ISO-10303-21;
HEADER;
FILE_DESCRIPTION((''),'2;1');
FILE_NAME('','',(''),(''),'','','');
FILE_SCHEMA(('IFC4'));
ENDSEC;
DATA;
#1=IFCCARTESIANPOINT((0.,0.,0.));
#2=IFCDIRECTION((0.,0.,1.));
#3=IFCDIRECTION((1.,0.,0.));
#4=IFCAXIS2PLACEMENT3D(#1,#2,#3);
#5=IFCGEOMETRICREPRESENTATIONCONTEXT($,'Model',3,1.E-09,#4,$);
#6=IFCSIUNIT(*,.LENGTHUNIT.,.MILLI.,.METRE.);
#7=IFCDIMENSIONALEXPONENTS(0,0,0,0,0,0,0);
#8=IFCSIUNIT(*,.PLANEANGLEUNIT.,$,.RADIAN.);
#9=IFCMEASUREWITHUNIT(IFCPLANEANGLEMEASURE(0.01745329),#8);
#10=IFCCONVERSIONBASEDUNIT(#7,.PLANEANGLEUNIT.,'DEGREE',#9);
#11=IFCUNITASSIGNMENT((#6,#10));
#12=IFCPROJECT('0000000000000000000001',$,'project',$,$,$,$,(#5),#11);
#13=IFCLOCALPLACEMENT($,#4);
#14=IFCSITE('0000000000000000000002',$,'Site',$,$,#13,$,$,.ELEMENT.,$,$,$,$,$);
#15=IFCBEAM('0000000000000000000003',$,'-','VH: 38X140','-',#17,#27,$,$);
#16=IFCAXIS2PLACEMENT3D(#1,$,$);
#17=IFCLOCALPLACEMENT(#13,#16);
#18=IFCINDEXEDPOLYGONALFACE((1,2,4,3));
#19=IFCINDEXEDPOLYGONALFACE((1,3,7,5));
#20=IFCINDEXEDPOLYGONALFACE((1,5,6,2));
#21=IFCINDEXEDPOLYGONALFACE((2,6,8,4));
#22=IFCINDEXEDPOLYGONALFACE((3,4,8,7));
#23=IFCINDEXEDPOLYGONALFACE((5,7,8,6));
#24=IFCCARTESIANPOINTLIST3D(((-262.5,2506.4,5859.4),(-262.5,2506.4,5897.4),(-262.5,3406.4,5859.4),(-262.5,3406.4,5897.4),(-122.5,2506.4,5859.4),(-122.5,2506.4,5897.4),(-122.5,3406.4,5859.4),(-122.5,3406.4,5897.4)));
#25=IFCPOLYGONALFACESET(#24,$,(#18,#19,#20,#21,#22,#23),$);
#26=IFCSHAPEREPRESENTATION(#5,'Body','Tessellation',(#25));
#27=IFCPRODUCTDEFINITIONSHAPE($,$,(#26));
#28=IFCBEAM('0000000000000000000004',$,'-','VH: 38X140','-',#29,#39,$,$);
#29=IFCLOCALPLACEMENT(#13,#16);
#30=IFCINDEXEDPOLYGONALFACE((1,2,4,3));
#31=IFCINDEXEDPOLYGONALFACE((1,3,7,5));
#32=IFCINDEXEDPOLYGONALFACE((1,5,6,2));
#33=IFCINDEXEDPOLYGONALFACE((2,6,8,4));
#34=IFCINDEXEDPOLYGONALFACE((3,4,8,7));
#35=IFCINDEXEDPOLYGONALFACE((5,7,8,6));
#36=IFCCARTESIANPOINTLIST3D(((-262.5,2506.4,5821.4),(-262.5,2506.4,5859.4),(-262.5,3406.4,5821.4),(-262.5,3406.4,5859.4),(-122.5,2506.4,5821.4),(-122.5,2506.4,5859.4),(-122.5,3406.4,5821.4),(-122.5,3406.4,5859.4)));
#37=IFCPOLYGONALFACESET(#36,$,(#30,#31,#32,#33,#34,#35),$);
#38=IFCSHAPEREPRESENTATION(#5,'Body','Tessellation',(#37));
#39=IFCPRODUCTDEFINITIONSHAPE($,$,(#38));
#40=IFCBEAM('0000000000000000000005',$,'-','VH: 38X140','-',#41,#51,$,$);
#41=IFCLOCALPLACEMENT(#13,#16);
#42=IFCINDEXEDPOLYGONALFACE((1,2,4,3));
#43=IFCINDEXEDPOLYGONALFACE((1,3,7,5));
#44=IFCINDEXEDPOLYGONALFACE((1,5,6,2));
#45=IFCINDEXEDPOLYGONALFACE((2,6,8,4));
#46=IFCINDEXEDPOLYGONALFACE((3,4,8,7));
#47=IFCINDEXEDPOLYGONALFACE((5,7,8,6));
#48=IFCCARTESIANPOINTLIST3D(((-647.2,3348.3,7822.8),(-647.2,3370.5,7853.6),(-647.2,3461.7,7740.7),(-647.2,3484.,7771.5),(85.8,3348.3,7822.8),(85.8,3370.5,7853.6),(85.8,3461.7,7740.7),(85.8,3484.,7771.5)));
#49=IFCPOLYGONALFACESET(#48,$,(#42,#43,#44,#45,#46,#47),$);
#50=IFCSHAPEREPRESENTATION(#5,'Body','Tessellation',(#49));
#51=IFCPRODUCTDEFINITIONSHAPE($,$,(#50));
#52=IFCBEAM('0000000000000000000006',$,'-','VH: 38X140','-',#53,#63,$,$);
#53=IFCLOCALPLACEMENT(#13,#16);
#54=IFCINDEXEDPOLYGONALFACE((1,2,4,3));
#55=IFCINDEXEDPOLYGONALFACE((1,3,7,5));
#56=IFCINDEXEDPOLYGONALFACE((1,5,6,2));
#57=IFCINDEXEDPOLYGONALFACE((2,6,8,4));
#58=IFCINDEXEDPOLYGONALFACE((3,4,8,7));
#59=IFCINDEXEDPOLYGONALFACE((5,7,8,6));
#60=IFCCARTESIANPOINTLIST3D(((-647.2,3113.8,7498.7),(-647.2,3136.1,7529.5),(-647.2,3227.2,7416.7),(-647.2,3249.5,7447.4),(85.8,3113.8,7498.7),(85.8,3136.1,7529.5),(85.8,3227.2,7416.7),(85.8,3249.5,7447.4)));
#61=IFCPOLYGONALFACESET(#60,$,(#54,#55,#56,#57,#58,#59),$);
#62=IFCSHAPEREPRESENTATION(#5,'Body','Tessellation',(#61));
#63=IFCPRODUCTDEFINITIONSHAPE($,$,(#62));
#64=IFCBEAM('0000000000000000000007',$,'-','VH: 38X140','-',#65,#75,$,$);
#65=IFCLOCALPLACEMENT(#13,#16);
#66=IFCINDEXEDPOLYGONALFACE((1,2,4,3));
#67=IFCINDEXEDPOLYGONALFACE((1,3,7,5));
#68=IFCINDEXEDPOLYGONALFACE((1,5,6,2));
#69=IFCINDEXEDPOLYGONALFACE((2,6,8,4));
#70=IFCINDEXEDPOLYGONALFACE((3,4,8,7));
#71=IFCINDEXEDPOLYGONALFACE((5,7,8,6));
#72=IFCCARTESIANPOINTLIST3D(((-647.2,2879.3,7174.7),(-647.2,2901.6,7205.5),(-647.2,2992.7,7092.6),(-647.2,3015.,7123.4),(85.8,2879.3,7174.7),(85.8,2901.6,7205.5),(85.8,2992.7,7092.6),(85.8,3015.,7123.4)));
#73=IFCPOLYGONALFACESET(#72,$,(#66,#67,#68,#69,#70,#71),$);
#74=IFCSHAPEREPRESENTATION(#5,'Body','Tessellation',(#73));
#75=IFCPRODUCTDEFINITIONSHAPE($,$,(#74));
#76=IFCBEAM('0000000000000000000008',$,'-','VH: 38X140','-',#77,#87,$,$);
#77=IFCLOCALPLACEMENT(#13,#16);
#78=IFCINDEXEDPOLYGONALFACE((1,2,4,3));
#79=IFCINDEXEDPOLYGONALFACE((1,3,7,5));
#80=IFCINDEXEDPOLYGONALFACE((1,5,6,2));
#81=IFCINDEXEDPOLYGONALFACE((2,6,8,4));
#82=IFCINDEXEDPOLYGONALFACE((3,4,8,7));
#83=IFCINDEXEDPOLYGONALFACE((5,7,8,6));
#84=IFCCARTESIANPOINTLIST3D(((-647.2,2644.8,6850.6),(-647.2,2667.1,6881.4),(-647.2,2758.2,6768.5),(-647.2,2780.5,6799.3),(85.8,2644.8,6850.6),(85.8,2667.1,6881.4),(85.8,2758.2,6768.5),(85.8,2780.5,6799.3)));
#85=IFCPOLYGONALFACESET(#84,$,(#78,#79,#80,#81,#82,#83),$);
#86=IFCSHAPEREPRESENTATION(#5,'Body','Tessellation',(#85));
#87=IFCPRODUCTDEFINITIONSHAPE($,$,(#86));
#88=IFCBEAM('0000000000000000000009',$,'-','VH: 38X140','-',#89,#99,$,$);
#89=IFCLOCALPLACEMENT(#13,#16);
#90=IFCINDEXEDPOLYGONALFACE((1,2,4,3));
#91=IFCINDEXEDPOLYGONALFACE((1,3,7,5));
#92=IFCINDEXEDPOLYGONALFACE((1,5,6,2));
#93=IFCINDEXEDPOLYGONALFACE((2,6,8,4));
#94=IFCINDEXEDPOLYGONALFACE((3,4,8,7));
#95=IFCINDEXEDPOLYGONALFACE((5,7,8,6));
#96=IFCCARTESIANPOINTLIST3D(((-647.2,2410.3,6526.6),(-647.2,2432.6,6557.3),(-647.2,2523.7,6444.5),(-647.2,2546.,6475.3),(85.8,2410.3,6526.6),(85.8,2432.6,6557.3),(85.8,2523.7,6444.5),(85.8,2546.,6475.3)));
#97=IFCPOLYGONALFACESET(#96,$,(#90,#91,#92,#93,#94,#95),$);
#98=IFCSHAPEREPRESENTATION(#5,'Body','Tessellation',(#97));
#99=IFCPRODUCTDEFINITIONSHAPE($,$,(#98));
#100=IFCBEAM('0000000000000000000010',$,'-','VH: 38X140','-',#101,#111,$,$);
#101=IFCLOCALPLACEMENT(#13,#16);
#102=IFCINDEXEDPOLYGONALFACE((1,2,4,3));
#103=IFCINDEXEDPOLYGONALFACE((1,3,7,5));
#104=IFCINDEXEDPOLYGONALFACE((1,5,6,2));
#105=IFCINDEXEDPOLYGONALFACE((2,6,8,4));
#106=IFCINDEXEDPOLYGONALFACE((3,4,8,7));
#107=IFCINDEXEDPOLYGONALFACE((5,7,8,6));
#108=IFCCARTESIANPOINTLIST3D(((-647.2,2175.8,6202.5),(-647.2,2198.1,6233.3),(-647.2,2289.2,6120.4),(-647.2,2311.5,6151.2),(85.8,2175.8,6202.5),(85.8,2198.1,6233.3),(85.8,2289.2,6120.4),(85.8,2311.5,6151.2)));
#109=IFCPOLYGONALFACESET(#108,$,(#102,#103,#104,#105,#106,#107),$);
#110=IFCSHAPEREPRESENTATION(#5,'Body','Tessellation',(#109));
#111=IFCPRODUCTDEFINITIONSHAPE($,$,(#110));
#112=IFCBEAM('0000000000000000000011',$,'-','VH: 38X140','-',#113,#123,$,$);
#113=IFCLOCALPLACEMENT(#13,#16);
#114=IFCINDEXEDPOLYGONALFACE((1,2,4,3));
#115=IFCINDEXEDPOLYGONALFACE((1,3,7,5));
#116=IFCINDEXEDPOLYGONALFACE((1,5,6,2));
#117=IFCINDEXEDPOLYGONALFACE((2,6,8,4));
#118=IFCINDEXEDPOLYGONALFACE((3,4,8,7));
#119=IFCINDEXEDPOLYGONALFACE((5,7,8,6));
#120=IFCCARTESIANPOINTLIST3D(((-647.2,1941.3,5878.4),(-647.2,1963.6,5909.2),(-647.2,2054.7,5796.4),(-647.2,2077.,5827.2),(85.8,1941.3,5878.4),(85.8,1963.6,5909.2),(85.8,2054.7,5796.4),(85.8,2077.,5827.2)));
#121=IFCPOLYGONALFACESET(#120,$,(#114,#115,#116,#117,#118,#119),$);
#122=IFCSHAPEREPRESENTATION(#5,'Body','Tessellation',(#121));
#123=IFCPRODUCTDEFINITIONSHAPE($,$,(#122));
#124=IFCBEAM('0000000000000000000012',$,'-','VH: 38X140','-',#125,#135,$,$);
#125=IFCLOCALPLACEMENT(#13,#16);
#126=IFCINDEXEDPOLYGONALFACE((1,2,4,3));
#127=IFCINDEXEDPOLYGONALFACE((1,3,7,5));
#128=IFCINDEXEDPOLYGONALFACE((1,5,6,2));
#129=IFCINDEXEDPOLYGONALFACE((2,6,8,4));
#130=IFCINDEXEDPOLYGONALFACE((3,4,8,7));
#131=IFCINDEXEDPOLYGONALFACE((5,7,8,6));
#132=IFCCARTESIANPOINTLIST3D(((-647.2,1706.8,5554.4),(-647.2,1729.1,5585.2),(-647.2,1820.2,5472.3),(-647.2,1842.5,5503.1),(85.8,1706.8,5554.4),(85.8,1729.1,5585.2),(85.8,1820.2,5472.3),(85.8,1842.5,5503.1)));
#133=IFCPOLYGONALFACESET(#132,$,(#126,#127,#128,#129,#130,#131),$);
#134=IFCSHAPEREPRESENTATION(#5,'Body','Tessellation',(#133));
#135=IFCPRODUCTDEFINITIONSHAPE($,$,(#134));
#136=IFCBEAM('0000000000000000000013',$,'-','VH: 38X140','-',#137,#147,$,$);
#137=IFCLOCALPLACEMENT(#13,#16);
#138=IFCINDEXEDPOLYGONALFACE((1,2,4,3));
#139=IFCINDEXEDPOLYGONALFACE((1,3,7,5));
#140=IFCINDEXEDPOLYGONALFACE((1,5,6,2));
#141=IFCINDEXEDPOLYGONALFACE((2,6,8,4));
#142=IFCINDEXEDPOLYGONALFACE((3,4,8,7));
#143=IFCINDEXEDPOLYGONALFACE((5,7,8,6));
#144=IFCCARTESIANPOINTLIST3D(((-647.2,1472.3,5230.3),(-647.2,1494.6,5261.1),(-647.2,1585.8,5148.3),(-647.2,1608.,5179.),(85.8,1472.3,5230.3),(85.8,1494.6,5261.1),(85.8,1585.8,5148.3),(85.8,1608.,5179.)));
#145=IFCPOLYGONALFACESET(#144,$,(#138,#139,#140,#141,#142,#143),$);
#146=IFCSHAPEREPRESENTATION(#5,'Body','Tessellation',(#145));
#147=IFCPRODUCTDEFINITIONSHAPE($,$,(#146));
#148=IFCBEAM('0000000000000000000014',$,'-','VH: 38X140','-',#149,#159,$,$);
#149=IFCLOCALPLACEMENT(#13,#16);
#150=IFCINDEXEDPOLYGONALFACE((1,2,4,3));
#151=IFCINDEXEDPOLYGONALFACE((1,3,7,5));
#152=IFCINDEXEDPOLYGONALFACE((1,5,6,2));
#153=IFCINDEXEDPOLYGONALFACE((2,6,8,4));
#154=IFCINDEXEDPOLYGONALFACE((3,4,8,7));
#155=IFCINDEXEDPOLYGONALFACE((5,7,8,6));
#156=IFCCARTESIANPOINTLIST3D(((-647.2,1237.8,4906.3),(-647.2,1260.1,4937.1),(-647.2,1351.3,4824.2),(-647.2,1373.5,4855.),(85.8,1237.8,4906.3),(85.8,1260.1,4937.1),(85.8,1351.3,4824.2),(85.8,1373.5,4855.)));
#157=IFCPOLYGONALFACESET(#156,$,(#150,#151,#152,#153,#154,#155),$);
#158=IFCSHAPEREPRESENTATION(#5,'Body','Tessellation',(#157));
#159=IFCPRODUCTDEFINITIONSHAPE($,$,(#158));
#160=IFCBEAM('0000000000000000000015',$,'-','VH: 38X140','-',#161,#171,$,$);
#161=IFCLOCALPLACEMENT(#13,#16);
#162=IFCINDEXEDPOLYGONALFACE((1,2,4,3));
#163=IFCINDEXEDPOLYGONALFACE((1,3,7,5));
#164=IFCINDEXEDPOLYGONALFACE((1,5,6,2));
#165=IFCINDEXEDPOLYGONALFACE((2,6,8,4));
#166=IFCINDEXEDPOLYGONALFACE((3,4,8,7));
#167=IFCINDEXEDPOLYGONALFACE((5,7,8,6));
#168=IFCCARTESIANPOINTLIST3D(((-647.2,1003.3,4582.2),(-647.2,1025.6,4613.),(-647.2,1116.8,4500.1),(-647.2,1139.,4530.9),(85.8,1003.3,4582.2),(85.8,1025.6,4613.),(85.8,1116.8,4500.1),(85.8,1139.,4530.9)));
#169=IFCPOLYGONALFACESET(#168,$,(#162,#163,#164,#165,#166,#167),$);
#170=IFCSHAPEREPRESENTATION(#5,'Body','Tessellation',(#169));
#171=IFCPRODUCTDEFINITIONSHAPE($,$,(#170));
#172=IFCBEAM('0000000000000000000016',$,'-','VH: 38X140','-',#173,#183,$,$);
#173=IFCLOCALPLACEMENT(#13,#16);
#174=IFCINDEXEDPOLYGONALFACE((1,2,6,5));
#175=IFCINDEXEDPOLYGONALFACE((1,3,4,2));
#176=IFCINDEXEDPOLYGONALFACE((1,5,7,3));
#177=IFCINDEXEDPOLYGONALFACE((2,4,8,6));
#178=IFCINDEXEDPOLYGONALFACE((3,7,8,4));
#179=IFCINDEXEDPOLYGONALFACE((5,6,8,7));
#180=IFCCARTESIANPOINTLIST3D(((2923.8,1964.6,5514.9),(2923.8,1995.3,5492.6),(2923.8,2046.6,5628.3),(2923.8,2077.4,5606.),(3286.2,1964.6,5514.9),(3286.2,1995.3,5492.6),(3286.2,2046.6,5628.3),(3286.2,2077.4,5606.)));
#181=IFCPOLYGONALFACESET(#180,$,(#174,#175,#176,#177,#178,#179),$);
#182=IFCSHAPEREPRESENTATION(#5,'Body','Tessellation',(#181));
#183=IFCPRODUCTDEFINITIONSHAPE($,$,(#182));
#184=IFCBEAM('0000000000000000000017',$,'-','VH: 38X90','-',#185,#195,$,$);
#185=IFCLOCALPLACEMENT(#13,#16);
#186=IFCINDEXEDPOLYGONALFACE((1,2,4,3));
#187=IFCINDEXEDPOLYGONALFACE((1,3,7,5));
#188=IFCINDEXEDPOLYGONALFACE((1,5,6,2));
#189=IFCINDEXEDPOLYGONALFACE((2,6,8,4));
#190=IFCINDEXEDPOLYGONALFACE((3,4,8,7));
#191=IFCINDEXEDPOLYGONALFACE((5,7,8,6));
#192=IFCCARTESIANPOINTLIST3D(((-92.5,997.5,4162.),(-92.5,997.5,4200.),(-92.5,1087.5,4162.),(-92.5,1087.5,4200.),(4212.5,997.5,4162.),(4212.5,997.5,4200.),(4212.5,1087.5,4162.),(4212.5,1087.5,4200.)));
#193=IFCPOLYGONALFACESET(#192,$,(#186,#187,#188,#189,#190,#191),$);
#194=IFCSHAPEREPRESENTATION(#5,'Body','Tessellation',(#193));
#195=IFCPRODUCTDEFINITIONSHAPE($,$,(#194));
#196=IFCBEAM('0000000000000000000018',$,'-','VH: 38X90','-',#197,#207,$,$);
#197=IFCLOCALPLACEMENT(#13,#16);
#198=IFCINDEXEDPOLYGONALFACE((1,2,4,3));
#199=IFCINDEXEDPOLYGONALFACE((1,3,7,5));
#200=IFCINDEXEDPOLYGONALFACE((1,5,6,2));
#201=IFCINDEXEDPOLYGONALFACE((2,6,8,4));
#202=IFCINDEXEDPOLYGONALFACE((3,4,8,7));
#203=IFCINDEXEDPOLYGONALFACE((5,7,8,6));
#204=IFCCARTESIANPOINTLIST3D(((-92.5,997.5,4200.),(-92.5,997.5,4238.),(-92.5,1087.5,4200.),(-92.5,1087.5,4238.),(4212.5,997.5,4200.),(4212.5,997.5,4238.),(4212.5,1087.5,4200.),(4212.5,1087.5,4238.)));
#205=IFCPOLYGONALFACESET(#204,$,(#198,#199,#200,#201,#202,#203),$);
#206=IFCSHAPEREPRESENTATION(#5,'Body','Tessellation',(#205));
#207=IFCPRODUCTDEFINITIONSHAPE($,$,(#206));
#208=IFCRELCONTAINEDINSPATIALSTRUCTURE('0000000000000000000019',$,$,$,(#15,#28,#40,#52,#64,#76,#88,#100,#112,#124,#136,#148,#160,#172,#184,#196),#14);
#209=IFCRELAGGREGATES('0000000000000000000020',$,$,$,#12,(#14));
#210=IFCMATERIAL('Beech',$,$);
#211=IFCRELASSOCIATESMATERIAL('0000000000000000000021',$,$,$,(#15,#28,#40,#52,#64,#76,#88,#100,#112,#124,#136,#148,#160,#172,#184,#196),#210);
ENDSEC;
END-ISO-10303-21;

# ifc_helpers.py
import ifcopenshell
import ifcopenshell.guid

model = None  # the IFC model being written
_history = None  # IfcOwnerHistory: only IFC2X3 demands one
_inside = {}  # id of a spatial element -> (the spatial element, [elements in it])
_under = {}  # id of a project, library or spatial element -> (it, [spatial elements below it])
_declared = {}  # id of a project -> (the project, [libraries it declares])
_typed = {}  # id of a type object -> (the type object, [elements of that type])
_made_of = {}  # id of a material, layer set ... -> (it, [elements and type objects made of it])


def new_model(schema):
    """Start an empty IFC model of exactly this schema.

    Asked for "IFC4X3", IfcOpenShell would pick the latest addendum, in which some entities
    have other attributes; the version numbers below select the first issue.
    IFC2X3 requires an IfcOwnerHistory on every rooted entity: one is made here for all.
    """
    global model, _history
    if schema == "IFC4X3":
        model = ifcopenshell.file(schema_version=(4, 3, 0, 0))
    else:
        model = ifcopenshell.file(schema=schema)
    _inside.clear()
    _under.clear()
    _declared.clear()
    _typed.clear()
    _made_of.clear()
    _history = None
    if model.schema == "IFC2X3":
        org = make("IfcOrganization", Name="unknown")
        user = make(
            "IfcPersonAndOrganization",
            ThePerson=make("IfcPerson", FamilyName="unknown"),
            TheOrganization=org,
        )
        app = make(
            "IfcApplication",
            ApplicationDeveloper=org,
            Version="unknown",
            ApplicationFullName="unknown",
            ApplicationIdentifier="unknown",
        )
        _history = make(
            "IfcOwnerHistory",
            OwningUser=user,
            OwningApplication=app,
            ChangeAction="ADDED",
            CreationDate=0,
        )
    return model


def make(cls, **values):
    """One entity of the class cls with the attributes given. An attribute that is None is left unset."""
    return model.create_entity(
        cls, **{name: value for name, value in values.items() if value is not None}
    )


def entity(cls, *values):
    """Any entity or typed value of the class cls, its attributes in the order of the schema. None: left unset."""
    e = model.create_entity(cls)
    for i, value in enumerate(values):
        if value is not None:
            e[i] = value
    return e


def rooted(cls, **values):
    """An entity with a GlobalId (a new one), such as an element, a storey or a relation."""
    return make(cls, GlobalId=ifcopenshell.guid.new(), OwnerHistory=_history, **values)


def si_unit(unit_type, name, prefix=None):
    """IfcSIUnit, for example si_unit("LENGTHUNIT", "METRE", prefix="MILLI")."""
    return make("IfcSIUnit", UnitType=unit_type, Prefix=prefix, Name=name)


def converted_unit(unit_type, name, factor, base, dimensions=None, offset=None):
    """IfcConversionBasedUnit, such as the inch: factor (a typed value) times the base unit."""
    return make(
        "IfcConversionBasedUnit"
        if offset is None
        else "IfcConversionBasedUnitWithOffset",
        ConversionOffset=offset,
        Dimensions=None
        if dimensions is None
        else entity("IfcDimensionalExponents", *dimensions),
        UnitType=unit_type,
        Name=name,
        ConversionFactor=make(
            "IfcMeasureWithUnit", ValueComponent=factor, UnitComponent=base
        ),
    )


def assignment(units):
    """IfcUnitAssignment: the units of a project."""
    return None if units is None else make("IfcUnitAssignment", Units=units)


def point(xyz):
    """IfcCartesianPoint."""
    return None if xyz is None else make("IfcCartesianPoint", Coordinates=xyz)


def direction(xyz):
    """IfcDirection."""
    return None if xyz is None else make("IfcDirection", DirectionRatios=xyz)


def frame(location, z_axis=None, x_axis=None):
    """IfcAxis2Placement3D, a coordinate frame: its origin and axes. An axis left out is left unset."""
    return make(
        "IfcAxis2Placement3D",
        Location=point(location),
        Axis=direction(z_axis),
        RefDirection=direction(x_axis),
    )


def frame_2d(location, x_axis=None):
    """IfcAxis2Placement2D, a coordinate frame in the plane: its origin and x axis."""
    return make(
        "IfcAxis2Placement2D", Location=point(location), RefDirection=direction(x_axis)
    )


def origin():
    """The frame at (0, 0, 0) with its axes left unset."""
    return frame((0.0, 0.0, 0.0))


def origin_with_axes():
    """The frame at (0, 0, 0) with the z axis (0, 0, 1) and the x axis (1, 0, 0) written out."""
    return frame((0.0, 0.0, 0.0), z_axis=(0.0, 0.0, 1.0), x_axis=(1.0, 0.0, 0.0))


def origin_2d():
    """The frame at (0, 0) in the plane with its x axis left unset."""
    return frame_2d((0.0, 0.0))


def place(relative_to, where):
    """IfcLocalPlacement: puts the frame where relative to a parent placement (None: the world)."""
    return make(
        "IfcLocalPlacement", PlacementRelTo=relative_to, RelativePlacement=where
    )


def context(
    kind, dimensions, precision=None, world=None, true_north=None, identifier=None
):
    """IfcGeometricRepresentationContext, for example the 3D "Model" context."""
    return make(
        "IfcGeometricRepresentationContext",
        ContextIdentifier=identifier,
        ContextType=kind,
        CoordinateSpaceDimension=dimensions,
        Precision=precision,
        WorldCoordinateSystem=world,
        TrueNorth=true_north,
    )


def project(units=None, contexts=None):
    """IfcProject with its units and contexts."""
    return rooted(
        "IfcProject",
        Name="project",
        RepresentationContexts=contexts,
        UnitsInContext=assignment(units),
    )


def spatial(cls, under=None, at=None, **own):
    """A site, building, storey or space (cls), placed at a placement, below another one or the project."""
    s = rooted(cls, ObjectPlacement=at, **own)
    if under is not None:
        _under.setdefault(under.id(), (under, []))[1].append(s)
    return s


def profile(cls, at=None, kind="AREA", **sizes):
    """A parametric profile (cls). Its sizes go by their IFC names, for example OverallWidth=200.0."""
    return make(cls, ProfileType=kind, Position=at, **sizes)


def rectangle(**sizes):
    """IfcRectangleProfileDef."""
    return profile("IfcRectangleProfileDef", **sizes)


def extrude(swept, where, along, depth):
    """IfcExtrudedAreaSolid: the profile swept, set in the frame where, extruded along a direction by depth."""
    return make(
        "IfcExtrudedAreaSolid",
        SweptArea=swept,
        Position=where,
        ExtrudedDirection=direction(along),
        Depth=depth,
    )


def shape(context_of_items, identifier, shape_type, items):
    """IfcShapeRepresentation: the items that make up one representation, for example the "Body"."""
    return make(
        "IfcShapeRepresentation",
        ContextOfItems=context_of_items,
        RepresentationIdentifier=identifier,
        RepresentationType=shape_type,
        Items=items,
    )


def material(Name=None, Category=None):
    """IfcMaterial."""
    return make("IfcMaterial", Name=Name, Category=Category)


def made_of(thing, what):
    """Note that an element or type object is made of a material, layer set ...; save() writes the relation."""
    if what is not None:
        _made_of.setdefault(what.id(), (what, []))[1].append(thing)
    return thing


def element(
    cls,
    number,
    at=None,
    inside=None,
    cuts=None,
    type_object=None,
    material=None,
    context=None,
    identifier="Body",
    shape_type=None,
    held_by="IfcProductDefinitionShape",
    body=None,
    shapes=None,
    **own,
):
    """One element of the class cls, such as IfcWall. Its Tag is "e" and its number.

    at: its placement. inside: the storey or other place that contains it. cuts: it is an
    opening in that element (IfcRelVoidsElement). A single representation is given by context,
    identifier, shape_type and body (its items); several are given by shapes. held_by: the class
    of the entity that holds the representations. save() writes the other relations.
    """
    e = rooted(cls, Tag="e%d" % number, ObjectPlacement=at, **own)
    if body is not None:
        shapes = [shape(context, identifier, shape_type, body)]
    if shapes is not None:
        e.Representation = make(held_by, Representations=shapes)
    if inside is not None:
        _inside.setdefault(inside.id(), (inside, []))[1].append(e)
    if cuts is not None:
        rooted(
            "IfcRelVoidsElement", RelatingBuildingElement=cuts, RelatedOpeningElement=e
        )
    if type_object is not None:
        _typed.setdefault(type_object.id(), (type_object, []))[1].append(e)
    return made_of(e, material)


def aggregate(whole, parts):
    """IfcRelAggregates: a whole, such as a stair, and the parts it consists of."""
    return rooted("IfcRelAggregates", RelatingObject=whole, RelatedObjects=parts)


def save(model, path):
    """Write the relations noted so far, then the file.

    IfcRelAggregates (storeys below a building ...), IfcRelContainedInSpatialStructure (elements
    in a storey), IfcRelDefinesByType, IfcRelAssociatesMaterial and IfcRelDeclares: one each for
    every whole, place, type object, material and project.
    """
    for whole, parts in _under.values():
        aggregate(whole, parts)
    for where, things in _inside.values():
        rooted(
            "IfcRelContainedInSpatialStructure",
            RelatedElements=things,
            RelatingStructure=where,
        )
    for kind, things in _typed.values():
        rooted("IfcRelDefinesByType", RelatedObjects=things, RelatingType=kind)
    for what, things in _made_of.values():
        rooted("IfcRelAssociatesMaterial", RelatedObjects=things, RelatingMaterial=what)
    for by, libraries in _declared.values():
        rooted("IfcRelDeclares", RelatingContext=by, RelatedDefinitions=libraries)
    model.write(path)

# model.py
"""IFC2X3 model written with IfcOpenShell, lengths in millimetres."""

from ifc_helpers import new_model, entity, si_unit, converted_unit, frame, origin, origin_with_axes, origin_2d, place, context, project, spatial, rectangle, extrude, material, element, save


model = new_model("IFC2X3")

# Units and contexts
model_context = context("Model", 3, precision=1e-09, world=origin_with_axes())
ifc_project = project(units=[si_unit("LENGTHUNIT", "METRE", prefix="MILLI"), converted_unit("PLANEANGLEUNIT", "DEGREE", entity("IfcPlaneAngleMeasure", 0.01745329), si_unit("PLANEANGLEUNIT", "RADIAN"), dimensions=[0, 0, 0, 0, 0, 0, 0])], contexts=[model_context])

# Site
site_placement = place(None, origin_with_axes())
site = spatial("IfcSite", under=ifc_project, at=site_placement, Name="Site", CompositionType="ELEMENT")

# Shared definitions
ifc_material = material(Name="Beech")

# Beams
for number, where, z_axis, x_axis, name in (
    (1, (-192.5, 3406.4, 5878.4), (0.0, 1.0, 0.0), (0.0, 0.0, -1.0), "-"),
    (2, (-192.5, 3406.4, 5840.4), (0.0, 1.0, 0.0), (0.0, 0.0, -1.0), "-"),
):
    element("IfcBeam", number, at=place(None, frame(where, z_axis=z_axis, x_axis=x_axis)), inside=site, material=ifc_material, Name=name, Description="VH: 38X140", ObjectType="-", context=model_context, shape_type="SweptSolid", body=[
        extrude(rectangle(XDim=38.0, YDim=140.0, at=origin_2d()), origin(), (0.0, 0.0, -1.0), 900.0),
    ])
for number, where, z_axis, x_axis, name in (
    (3, (-647.2, 3416.1, 7797.2), (1.0, 0.0, 0.0), (0.0, 0.58623, 0.810145), "-"),
    (4, (-647.2, 3181.6, 7473.1), (1.0, 0.0, 0.0), (0.0, 0.58623, 0.810145), "-"),
    (5, (-647.2, 2947.1, 7149.0), (1.0, 0.0, 0.0), (0.0, 0.58623, 0.810145), "-"),
    (6, (-647.2, 2712.6, 6825.0), (1.0, 0.0, 0.0), (0.0, 0.58623, 0.810145), "-"),
    (7, (-647.2, 2478.1, 6500.9), (1.0, 0.0, 0.0), (0.0, 0.58623, 0.810145), "-"),
    (8, (-647.2, 2243.7, 6176.9), (1.0, 0.0, 0.0), (0.0, 0.58623, 0.810145), "-"),
    (9, (-647.2, 2009.2, 5852.8), (1.0, 0.0, 0.0), (0.0, 0.58623, 0.810145), "-"),
    (10, (-647.2, 1774.7, 5528.7), (1.0, 0.0, 0.0), (0.0, 0.58623, 0.810145), "-"),
    (11, (-647.2, 1540.2, 5204.7), (1.0, 0.0, 0.0), (0.0, 0.58623, 0.810145), "-"),
    (12, (-647.2, 1305.7, 4880.6), (1.0, 0.0, 0.0), (0.0, 0.58623, 0.810145), "-"),
    (13, (-647.2, 1071.2, 4556.6), (1.0, 0.0, 0.0), (0.0, 0.58623, 0.810145), "-"),
):
    element("IfcBeam", number, at=place(None, frame(where, z_axis=z_axis, x_axis=x_axis)), inside=site, material=ifc_material, Name=name, Description="VH: 38X140", ObjectType="-", context=model_context, shape_type="SweptSolid", body=[
        extrude(rectangle(XDim=38.0, YDim=140.0, at=origin_2d()), origin(), (0.0, 0.0, 1.0), 733.0),
    ])
beam_1_placement = place(None, frame((2923.8, 2021.0, 5560.4), z_axis=(-1.0, 0.000006, -0.000004), x_axis=(0.000007, 0.810145, -0.58623)))
element("IfcBeam", 14, at=beam_1_placement, inside=site, material=ifc_material, Name="-", Description="VH: 38X140", ObjectType="-", context=model_context, shape_type="SweptSolid", body=[
    extrude(rectangle(XDim=38.0, YDim=140.0, at=origin_2d()), origin(), (0.0, 0.0, -1.0), 362.5),
])
for number, where, z_axis, x_axis, name in (
    (15, (-92.5, 1042.5, 4181.0), (-1.0, 0.0, 0.0), (0.0, 0.0, 1.0), "-"),
    (16, (-92.5, 1042.5, 4219.0), (-1.0, 0.0, 0.0), (0.0, 0.0, 1.0), "-"),
):
    element("IfcBeam", number, at=place(None, frame(where, z_axis=z_axis, x_axis=x_axis)), inside=site, material=ifc_material, Name=name, Description="VH: 38X90", ObjectType="-", context=model_context, shape_type="SweptSolid", body=[
        extrude(rectangle(XDim=38.0, YDim=90.0, at=origin_2d()), origin(), (0.0, 0.0, -1.0), 4305.0),
    ])

save(model, "model.ifc")
